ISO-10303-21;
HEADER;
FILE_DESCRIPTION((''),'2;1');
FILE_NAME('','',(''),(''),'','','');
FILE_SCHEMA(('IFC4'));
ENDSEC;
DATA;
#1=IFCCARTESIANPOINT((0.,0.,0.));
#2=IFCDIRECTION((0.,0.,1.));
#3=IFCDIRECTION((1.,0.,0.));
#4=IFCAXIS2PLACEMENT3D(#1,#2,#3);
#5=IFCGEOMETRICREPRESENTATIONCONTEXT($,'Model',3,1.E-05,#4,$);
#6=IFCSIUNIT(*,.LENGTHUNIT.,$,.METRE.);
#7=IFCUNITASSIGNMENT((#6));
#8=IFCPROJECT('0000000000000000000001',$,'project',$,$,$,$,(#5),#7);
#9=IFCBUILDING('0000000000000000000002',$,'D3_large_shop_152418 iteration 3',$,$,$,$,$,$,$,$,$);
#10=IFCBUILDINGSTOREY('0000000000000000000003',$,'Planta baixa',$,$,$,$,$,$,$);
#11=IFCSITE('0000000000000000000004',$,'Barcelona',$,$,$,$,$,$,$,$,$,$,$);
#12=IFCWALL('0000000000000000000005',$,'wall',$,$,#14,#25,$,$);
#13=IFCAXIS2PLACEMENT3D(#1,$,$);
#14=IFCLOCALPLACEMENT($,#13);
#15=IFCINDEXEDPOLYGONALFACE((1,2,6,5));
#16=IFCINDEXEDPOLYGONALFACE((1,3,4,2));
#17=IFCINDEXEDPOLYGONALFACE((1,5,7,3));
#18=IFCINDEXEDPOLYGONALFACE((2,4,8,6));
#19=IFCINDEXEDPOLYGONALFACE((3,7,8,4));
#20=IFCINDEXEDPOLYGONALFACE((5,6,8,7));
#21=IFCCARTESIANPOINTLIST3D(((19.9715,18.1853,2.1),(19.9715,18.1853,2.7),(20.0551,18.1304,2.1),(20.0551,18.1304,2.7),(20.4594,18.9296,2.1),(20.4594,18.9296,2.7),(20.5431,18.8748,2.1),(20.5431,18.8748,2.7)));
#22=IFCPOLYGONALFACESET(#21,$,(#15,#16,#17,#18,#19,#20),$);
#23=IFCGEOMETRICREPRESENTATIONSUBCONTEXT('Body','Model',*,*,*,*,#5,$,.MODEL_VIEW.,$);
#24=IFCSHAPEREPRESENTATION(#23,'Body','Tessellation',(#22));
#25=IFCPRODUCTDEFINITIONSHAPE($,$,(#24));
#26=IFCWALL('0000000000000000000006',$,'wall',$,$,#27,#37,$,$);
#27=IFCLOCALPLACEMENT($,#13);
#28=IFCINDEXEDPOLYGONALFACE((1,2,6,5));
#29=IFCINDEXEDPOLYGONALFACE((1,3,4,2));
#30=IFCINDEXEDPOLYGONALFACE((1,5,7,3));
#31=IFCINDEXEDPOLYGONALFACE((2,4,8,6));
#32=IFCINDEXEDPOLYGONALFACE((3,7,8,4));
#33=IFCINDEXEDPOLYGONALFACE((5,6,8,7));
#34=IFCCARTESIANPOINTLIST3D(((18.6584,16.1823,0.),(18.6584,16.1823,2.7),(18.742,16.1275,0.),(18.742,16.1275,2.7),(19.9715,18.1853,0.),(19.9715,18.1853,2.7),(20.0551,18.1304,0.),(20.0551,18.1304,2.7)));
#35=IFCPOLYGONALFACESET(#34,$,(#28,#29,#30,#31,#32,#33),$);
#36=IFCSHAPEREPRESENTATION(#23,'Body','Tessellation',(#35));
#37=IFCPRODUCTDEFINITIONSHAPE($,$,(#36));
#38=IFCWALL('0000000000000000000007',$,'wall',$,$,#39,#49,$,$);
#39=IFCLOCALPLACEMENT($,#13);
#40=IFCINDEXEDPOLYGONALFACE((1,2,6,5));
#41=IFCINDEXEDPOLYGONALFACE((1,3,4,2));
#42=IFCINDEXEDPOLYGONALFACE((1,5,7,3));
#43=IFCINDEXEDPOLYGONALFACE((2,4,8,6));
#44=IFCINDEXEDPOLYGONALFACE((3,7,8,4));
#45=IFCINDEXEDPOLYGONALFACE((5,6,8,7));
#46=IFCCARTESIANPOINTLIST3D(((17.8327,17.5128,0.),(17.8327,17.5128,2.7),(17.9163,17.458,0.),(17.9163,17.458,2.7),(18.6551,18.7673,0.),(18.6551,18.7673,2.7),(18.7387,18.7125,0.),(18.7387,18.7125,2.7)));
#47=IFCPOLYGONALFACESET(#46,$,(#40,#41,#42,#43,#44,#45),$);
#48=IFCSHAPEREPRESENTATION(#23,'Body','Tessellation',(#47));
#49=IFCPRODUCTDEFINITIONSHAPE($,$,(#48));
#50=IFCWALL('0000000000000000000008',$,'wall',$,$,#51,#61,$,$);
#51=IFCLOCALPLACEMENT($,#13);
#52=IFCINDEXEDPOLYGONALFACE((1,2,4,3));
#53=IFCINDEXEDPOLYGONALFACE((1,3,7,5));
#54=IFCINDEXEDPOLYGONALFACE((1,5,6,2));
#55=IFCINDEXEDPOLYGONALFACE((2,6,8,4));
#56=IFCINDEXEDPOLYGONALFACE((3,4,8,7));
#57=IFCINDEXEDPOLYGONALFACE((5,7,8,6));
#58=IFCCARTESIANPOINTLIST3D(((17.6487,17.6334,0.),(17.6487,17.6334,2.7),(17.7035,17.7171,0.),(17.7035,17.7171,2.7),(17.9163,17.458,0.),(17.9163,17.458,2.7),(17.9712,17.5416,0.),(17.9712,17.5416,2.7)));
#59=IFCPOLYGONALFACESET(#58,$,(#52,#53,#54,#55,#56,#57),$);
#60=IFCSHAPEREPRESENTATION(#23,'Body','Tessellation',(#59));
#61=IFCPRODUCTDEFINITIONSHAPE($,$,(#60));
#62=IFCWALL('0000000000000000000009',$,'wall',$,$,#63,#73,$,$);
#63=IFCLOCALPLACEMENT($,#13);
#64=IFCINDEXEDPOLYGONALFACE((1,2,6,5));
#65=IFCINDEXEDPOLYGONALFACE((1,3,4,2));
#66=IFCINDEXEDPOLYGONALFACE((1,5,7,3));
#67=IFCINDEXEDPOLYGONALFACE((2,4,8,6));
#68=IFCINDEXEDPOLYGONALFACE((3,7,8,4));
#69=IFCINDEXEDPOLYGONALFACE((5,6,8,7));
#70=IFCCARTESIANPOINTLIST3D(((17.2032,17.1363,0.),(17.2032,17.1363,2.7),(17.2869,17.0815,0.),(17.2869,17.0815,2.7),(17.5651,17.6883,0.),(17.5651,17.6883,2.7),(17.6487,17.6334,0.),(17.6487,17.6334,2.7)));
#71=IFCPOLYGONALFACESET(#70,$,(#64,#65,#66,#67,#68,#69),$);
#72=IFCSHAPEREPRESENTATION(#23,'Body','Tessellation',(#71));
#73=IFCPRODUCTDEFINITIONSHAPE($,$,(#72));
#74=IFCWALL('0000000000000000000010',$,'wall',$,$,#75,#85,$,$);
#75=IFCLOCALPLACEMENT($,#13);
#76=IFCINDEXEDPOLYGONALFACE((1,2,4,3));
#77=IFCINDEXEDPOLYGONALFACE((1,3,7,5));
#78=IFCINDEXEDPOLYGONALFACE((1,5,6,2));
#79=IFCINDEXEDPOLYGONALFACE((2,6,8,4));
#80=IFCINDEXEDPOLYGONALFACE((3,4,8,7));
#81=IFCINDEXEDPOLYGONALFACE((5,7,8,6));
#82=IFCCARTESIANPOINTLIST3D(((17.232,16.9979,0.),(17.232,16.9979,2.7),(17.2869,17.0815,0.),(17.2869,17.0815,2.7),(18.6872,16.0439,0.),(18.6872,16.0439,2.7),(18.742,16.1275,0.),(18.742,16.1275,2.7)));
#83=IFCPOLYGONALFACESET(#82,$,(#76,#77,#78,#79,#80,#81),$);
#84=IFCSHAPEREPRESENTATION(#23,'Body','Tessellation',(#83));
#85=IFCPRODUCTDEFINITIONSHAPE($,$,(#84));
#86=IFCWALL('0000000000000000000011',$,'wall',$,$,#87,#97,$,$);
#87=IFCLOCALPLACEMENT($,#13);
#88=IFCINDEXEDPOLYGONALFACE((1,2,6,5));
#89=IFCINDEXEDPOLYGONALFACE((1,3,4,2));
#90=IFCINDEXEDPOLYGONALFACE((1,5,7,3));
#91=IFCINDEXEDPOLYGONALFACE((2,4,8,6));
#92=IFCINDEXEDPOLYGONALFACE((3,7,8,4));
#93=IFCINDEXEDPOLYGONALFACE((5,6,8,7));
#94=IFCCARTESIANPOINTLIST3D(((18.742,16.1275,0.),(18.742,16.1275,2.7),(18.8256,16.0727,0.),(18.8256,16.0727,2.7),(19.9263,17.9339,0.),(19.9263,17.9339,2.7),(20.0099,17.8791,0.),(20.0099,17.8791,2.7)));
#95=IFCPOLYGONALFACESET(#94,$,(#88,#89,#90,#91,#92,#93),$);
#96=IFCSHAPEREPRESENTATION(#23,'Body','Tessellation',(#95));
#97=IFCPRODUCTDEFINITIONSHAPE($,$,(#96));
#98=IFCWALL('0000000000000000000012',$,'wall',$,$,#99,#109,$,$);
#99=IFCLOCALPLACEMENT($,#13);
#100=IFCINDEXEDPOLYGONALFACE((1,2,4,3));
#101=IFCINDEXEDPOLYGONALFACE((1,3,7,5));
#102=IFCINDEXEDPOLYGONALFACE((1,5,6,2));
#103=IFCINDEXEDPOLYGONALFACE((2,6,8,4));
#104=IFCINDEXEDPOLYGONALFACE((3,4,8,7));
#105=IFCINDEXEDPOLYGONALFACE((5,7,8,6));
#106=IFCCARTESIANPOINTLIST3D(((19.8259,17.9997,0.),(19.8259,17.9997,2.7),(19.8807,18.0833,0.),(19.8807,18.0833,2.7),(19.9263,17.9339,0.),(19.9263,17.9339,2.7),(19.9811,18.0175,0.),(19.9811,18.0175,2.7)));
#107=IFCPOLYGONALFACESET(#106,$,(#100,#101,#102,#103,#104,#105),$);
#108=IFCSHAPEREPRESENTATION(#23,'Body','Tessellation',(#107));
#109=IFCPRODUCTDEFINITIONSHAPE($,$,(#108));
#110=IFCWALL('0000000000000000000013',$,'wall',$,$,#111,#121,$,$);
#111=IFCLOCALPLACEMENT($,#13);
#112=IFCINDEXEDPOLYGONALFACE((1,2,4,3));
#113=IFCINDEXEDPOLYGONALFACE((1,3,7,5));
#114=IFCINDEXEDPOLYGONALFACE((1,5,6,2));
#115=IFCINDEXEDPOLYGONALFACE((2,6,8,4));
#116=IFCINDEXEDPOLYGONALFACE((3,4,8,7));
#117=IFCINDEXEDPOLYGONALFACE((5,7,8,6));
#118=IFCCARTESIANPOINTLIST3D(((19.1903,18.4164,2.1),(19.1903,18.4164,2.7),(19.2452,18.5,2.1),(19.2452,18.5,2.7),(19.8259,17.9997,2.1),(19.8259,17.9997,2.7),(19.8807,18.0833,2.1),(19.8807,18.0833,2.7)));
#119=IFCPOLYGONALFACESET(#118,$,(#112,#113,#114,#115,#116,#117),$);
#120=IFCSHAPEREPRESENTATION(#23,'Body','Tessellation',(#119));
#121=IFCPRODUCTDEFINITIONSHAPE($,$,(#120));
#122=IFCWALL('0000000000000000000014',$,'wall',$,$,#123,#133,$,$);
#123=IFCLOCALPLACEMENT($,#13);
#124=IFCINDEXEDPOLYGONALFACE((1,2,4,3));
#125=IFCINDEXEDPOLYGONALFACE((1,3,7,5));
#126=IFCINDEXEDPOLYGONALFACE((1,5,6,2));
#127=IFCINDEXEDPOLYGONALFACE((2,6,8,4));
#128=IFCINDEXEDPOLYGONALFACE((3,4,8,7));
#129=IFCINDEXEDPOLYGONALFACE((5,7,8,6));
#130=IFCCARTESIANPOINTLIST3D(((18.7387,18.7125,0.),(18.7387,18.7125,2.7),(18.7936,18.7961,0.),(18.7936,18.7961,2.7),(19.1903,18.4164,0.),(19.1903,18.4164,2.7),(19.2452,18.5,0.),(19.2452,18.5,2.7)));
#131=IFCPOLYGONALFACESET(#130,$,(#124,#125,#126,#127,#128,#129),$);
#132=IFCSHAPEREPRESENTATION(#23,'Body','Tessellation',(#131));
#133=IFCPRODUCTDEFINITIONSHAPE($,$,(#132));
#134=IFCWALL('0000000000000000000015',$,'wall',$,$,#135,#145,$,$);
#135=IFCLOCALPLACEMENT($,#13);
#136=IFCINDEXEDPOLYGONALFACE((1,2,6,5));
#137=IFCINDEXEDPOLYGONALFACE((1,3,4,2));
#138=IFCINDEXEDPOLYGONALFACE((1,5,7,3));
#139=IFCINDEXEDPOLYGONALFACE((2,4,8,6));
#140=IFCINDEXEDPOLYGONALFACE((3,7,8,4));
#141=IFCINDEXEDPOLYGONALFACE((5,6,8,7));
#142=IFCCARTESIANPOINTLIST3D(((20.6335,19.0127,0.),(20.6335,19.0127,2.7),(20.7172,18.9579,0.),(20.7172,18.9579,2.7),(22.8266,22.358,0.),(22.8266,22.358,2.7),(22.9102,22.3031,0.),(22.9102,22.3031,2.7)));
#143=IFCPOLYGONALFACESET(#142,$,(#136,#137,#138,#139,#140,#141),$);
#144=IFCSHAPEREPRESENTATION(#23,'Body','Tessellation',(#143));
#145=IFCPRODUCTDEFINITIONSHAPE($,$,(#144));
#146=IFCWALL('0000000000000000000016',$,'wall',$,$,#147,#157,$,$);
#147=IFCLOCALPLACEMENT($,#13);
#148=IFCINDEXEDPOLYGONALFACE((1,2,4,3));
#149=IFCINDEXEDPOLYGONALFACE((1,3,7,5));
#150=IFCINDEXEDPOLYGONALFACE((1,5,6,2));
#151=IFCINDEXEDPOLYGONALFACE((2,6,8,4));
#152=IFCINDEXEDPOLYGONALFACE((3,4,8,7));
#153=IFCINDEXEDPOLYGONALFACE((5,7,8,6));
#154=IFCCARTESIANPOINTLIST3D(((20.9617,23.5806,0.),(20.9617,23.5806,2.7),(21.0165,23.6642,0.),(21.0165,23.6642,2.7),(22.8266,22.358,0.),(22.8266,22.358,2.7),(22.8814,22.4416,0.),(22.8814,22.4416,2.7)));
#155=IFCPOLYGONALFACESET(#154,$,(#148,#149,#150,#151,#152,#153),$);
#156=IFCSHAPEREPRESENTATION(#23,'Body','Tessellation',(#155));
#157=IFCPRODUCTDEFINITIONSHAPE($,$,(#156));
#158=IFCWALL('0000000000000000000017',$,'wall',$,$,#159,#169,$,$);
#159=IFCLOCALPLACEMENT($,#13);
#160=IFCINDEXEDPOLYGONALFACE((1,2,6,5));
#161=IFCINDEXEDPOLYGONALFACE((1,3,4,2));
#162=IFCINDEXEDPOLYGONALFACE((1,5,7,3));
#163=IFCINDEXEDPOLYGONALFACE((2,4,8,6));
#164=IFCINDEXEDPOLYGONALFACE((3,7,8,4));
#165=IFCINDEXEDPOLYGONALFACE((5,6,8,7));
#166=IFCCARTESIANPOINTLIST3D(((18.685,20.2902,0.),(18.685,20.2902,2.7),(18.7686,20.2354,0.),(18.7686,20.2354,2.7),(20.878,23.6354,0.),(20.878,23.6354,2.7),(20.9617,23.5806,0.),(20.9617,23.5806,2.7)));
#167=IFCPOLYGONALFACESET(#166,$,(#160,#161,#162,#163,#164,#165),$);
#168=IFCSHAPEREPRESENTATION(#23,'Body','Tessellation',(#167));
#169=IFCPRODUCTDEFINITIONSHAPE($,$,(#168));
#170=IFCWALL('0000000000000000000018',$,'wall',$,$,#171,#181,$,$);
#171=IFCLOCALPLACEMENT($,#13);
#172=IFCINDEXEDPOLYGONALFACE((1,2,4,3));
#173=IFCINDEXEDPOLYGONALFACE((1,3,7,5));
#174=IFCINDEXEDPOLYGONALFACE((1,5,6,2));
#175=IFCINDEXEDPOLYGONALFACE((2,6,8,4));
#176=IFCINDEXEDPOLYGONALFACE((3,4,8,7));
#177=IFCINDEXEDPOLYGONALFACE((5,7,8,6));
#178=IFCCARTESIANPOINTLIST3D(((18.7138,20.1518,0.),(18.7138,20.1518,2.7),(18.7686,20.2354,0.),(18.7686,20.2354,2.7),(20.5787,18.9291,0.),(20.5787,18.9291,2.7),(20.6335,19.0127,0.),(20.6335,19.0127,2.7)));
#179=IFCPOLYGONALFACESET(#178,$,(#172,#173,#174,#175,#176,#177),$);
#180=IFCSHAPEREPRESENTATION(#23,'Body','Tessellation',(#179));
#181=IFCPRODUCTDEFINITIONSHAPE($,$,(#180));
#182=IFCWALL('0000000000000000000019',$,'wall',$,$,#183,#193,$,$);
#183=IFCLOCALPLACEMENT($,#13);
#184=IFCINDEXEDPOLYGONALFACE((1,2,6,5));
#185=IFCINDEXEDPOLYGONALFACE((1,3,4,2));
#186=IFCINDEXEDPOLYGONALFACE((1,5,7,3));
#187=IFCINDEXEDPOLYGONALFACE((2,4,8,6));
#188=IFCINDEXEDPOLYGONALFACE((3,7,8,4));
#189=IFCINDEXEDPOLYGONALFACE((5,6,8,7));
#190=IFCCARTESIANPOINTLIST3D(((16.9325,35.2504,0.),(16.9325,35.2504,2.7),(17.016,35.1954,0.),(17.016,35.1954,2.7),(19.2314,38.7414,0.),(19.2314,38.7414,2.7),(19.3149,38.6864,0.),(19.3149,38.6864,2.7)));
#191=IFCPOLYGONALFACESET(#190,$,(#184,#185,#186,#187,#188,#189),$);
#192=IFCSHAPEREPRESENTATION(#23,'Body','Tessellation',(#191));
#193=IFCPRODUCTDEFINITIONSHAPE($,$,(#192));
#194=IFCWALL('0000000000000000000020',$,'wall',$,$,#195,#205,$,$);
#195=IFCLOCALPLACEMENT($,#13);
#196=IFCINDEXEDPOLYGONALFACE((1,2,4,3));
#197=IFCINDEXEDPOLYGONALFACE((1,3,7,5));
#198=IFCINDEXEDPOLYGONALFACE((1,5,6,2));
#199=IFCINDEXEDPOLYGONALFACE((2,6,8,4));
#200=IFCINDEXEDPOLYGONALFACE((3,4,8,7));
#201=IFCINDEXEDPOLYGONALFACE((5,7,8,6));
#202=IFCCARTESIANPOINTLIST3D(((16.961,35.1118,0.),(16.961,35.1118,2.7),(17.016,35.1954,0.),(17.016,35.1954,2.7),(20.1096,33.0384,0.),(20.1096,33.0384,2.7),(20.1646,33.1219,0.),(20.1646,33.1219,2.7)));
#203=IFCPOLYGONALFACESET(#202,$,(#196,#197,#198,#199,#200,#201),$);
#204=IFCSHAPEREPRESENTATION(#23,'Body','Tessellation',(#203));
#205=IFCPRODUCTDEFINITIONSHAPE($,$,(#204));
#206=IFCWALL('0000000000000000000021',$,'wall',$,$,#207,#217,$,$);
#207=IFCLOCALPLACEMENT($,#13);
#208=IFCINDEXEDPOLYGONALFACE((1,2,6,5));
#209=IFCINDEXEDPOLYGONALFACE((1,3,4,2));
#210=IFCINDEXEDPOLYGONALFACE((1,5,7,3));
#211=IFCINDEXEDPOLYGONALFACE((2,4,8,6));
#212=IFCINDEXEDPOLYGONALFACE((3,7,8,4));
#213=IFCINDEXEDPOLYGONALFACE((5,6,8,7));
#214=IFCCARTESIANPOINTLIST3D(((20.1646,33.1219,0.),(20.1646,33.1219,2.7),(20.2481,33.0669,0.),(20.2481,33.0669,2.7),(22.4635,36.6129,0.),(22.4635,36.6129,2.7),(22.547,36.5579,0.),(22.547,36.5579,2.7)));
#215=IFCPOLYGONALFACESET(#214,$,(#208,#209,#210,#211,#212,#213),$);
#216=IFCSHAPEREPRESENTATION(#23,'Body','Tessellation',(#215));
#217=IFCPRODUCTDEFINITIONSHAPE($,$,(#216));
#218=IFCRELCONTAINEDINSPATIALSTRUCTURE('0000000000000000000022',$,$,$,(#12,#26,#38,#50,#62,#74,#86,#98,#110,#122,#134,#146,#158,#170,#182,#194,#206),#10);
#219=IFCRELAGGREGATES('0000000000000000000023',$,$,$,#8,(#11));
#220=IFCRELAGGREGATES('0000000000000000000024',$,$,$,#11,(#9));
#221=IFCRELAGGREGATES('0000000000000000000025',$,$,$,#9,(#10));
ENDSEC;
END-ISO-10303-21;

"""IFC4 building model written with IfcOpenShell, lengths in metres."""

from ifc_helpers import new_model, si_unit, frame, origin, origin_with_axes, place, context, subcontext, project, spatial, polyline, outline, extrude, element, save


model = new_model("IFC4")

# Units and contexts
model_context = context("Model", 3, precision=1e-05, world=origin_with_axes())
body_context = subcontext(model_context, "Body", "Model", "MODEL_VIEW")
ifc_project = project(units=[si_unit("LENGTHUNIT", "METRE")], contexts=[model_context])

# Site, building, storey
site = spatial("IfcSite", under=ifc_project, Name="Barcelona")
building = spatial("IfcBuilding", under=site, Name="D3_large_shop_152418 iteration 3")
storey = spatial("IfcBuildingStorey", under=building, Name="Planta baixa")

# Walls
wall_1_placement = place(None, origin_with_axes())
element("IfcWall", 1, at=wall_1_placement, inside=storey, Name="wall", context=body_context, shape_type="SweptSolid", body=[
    extrude(outline(polyline([(20.5431, 18.8748), (20.0551, 18.1304), (19.9715, 18.1853), (20.4594, 18.9296), (20.5431, 18.8748)])), frame((0.0, 0.0, 2.1)), (0.0, 0.0, 1.0), 0.6),
])
wall_2_placement = place(None, origin_with_axes())
element("IfcWall", 2, at=wall_2_placement, inside=storey, Name="wall", context=body_context, shape_type="SweptSolid", body=[
    extrude(outline(polyline([(20.0551, 18.1304), (18.742, 16.1275), (18.6584, 16.1823), (19.9715, 18.1853), (20.0551, 18.1304)])), origin(), (0.0, 0.0, 1.0), 2.7),
])
wall_3_placement = place(None, origin_with_axes())
element("IfcWall", 3, at=wall_3_placement, inside=storey, Name="wall", context=body_context, shape_type="SweptSolid", body=[
    extrude(outline(polyline([(18.7387, 18.7125), (17.9163, 17.458), (17.8327, 17.5128), (18.6551, 18.7673), (18.7387, 18.7125)])), origin(), (0.0, 0.0, 1.0), 2.7),
])
wall_4_placement = place(None, origin_with_axes())
element("IfcWall", 4, at=wall_4_placement, inside=storey, Name="wall", context=body_context, shape_type="SweptSolid", body=[
    extrude(outline(polyline([(17.9163, 17.458), (17.6487, 17.6334), (17.7035, 17.7171), (17.9712, 17.5416), (17.9163, 17.458)])), origin(), (0.0, 0.0, 1.0), 2.7),
])
wall_5_placement = place(None, origin_with_axes())
element("IfcWall", 5, at=wall_5_placement, inside=storey, Name="wall", context=body_context, shape_type="SweptSolid", body=[
    extrude(outline(polyline([(17.6487, 17.6334), (17.2869, 17.0815), (17.2032, 17.1363), (17.5651, 17.6883), (17.6487, 17.6334)])), origin(), (0.0, 0.0, 1.0), 2.7),
])
wall_6_placement = place(None, origin_with_axes())
element("IfcWall", 6, at=wall_6_placement, inside=storey, Name="wall", context=body_context, shape_type="SweptSolid", body=[
    extrude(outline(polyline([(17.2869, 17.0815), (18.742, 16.1275), (18.6872, 16.0439), (17.232, 16.9979), (17.2869, 17.0815)])), origin(), (0.0, 0.0, 1.0), 2.7),
])
wall_7_placement = place(None, origin_with_axes())
element("IfcWall", 7, at=wall_7_placement, inside=storey, Name="wall", context=body_context, shape_type="SweptSolid", body=[
    extrude(outline(polyline([(18.742, 16.1275), (19.9263, 17.9339), (20.0099, 17.8791), (18.8256, 16.0727), (18.742, 16.1275)])), origin(), (0.0, 0.0, 1.0), 2.7),
])
wall_8_placement = place(None, origin_with_axes())
element("IfcWall", 8, at=wall_8_placement, inside=storey, Name="wall", context=body_context, shape_type="SweptSolid", body=[
    extrude(outline(polyline([(19.9263, 17.9339), (19.8259, 17.9997), (19.8807, 18.0833), (19.9811, 18.0175), (19.9263, 17.9339)])), origin(), (0.0, 0.0, 1.0), 2.7),
])
wall_9_placement = place(None, origin_with_axes())
element("IfcWall", 9, at=wall_9_placement, inside=storey, Name="wall", context=body_context, shape_type="SweptSolid", body=[
    extrude(outline(polyline([(19.8259, 17.9997), (19.1903, 18.4164), (19.2452, 18.5), (19.8807, 18.0833), (19.8259, 17.9997)])), frame((0.0, 0.0, 2.1)), (0.0, 0.0, 1.0), 0.6),
])
wall_10_placement = place(None, origin_with_axes())
element("IfcWall", 10, at=wall_10_placement, inside=storey, Name="wall", context=body_context, shape_type="SweptSolid", body=[
    extrude(outline(polyline([(19.1903, 18.4164), (18.7387, 18.7125), (18.7936, 18.7961), (19.2452, 18.5), (19.1903, 18.4164)])), origin(), (0.0, 0.0, 1.0), 2.7),
])
wall_11_placement = place(None, origin_with_axes())
element("IfcWall", 11, at=wall_11_placement, inside=storey, Name="wall", context=body_context, shape_type="SweptSolid", body=[
    extrude(outline(polyline([(20.6335, 19.0127), (22.8266, 22.358), (22.9102, 22.3031), (20.7172, 18.9579), (20.6335, 19.0127)])), origin(), (0.0, 0.0, 1.0), 2.7),
])
wall_12_placement = place(None, origin_with_axes())
element("IfcWall", 12, at=wall_12_placement, inside=storey, Name="wall", context=body_context, shape_type="SweptSolid", body=[
    extrude(outline(polyline([(22.8266, 22.358), (20.9617, 23.5806), (21.0165, 23.6642), (22.8814, 22.4416), (22.8266, 22.358)])), origin(), (0.0, 0.0, 1.0), 2.7),
])
wall_13_placement = place(None, origin_with_axes())
element("IfcWall", 13, at=wall_13_placement, inside=storey, Name="wall", context=body_context, shape_type="SweptSolid", body=[
    extrude(outline(polyline([(20.9617, 23.5806), (18.7686, 20.2354), (18.685, 20.2902), (20.878, 23.6354), (20.9617, 23.5806)])), origin(), (0.0, 0.0, 1.0), 2.7),
])
wall_14_placement = place(None, origin_with_axes())
element("IfcWall", 14, at=wall_14_placement, inside=storey, Name="wall", context=body_context, shape_type="SweptSolid", body=[
    extrude(outline(polyline([(18.7686, 20.2354), (20.6335, 19.0127), (20.5787, 18.9291), (18.7138, 20.1518), (18.7686, 20.2354)])), origin(), (0.0, 0.0, 1.0), 2.7),
])
wall_15_placement = place(None, origin_with_axes())
element("IfcWall", 15, at=wall_15_placement, inside=storey, Name="wall", context=body_context, shape_type="SweptSolid", body=[
    extrude(outline(polyline([(19.3149, 38.6864), (17.016, 35.1954), (16.9325, 35.2504), (19.2314, 38.7414), (19.3149, 38.6864)])), origin(), (0.0, 0.0, 1.0), 2.7),
])
wall_16_placement = place(None, origin_with_axes())
element("IfcWall", 16, at=wall_16_placement, inside=storey, Name="wall", context=body_context, shape_type="SweptSolid", body=[
    extrude(outline(polyline([(17.016, 35.1954), (20.1646, 33.1219), (20.1096, 33.0384), (16.961, 35.1118), (17.016, 35.1954)])), origin(), (0.0, 0.0, 1.0), 2.7),
])
wall_17_placement = place(None, origin_with_axes())
element("IfcWall", 17, at=wall_17_placement, inside=storey, Name="wall", context=body_context, shape_type="SweptSolid", body=[
    extrude(outline(polyline([(20.1646, 33.1219), (22.4635, 36.6129), (22.547, 36.5579), (20.2481, 33.0669), (20.1646, 33.1219)])), origin(), (0.0, 0.0, 1.0), 2.7),
])

save(model, "model.ifc")
